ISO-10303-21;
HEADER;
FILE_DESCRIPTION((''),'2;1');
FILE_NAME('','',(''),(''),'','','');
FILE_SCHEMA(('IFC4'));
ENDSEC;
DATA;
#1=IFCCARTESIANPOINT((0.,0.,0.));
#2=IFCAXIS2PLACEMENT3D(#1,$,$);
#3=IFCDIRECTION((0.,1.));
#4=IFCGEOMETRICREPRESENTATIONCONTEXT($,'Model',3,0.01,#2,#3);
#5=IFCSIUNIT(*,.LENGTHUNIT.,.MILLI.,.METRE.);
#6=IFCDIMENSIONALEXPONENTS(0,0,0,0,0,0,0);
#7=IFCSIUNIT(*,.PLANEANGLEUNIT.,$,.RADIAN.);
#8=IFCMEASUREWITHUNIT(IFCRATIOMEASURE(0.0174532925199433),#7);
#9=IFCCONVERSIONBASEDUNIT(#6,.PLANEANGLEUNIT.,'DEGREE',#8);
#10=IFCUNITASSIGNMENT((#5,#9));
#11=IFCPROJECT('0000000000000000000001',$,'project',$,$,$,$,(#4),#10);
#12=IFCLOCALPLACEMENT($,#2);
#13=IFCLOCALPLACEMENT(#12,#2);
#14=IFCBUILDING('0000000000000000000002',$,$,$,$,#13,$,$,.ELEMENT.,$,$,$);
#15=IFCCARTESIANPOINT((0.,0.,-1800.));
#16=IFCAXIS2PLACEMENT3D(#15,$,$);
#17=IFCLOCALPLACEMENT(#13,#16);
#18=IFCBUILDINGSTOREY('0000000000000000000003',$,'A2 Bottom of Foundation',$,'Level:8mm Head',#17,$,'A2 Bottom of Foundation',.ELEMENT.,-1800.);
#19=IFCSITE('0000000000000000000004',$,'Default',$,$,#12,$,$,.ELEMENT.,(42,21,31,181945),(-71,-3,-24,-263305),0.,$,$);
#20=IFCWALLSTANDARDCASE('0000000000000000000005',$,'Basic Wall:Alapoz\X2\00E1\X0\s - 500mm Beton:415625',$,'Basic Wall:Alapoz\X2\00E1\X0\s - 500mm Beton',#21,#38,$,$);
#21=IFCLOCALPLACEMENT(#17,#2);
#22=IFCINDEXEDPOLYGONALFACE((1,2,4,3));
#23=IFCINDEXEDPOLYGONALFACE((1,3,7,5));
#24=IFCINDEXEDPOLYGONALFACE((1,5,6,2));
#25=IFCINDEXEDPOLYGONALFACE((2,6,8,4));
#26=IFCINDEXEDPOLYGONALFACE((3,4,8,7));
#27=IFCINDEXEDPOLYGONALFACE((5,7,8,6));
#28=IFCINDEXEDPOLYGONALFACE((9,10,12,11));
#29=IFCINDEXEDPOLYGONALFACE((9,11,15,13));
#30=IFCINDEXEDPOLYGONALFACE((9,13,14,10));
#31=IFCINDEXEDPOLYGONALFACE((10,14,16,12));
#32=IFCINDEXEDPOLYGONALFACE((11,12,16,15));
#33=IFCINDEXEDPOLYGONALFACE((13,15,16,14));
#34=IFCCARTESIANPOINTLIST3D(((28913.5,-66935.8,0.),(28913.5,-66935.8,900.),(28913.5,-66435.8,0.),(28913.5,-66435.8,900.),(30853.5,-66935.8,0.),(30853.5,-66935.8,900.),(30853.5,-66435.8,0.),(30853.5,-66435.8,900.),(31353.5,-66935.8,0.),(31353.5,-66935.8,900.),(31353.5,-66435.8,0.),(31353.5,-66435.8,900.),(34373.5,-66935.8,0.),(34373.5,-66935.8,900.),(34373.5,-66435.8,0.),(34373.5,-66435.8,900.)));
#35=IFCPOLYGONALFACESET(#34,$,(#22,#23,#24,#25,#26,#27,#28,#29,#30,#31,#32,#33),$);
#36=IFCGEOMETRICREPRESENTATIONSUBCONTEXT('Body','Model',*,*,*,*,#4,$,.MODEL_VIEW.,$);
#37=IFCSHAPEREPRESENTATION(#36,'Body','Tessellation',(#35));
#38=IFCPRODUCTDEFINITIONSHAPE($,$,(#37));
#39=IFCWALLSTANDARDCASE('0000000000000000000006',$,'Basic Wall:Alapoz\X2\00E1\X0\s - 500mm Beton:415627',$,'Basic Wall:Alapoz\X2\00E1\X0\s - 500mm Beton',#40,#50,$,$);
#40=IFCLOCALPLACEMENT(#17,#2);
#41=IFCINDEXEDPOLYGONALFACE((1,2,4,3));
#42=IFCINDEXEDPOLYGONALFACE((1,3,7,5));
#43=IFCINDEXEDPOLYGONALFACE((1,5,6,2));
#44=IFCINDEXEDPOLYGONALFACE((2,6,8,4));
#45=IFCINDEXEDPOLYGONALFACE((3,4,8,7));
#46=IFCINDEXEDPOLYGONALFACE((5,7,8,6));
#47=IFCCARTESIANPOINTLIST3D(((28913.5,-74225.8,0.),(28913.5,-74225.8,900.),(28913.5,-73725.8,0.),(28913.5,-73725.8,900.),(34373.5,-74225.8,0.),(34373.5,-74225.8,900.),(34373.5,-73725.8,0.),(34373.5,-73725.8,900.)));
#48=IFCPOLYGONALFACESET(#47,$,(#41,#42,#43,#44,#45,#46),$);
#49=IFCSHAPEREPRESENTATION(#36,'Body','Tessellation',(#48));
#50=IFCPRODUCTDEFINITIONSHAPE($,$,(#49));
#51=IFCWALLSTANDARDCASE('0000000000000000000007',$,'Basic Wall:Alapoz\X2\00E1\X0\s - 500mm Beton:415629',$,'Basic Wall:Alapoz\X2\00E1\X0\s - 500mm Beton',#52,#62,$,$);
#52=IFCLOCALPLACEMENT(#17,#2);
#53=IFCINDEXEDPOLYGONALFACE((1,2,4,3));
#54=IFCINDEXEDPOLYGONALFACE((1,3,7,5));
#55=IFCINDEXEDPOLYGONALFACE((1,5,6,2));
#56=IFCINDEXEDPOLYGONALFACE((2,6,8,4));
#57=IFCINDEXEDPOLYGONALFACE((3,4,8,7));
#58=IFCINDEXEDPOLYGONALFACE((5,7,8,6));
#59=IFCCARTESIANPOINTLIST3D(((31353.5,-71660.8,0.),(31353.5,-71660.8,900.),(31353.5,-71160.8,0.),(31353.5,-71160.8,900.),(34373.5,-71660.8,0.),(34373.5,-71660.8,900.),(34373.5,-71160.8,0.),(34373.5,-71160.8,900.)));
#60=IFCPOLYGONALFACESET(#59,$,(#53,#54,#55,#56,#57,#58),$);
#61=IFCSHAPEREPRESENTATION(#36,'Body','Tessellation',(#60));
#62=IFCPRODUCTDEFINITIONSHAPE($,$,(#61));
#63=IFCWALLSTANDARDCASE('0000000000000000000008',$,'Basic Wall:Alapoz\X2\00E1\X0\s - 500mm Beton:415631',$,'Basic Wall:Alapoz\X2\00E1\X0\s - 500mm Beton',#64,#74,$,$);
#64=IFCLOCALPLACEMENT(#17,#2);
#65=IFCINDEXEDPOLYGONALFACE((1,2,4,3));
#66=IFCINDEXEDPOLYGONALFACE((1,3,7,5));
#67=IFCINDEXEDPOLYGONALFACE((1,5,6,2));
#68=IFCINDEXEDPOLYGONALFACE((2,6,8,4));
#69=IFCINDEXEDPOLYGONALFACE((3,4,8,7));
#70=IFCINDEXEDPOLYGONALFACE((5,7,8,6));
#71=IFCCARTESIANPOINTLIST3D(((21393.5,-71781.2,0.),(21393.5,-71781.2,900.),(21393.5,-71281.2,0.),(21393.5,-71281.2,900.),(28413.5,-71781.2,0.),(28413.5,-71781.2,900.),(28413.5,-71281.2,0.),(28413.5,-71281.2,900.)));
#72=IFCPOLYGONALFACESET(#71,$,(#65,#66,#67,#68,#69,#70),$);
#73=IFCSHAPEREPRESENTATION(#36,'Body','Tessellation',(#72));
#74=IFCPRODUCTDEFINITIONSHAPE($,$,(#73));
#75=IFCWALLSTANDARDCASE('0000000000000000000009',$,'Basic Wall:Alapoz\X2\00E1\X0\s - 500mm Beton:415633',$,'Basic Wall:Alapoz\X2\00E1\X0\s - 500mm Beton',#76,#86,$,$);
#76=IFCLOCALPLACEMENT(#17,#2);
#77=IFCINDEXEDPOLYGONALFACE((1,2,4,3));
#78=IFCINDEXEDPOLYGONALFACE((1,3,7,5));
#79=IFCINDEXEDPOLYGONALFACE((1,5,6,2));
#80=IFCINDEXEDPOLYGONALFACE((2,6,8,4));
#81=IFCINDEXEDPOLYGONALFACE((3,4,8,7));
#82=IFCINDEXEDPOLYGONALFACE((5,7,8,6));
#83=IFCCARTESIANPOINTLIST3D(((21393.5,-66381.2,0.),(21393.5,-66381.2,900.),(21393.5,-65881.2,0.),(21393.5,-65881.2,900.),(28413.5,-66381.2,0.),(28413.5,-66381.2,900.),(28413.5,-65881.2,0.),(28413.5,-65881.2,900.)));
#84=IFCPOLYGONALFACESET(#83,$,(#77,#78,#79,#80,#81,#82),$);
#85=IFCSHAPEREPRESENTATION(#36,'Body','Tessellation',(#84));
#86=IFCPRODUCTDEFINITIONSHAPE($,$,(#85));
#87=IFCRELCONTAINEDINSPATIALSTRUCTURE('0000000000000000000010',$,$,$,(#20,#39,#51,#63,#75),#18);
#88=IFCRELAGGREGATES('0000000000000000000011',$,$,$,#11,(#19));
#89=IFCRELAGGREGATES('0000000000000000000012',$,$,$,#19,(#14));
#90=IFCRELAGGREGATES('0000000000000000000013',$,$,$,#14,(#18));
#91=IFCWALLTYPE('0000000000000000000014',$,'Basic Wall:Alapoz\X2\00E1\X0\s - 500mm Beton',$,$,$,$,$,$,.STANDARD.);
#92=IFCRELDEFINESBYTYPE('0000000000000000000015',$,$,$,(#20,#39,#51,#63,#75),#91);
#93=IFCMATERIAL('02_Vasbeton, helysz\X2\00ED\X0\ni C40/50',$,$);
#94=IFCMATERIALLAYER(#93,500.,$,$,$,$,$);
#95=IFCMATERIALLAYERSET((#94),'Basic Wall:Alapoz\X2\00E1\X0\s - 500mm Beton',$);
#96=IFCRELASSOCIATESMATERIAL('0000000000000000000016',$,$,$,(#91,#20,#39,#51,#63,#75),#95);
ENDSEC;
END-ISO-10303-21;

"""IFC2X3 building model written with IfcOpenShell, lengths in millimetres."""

from ifc_helpers import new_model, entity, si_unit, converted_unit, direction, frame, frame_2d, origin, place, context, subcontext, project, spatial, rectangle, extrude, material, layer, layer_set, layer_usage, type_object, element, save


model = new_model("IFC2X3")

# Units and contexts
model_context = context("Model", 3, precision=0.01, world=origin(), true_north=direction((0.0, 1.0)))
body_context = subcontext(model_context, "Body", "Model", "MODEL_VIEW")
ifc_project = project(units=[si_unit("LENGTHUNIT", "METRE", prefix="MILLI"), converted_unit("PLANEANGLEUNIT", "DEGREE", entity("IfcRatioMeasure", 0.0174532925199433), si_unit("PLANEANGLEUNIT", "RADIAN"), dimensions=[0, 0, 0, 0, 0, 0, 0])], contexts=[model_context])

# Site, building, storey
site_placement = place(None, origin())
site = spatial("IfcSite", under=ifc_project, at=site_placement, Name="Default", CompositionType="ELEMENT", RefLatitude=(42, 21, 31, 181945), RefLongitude=(-71, -3, -24, -263305), RefElevation=0.0)
building_placement = place(site_placement, origin())
building = spatial("IfcBuilding", under=site, at=building_placement, CompositionType="ELEMENT")
storey_placement = place(building_placement, frame((0.0, 0.0, -1800.0)))
storey = spatial("IfcBuildingStorey", under=building, at=storey_placement, Name="A2 Bottom of Foundation", ObjectType="Level:8mm Head", LongName="A2 Bottom of Foundation", CompositionType="ELEMENT", Elevation=-1800.0)

# Shared definitions
ifc_material = material(Name="02_Vasbeton, helyszíni C40/50")
ifc_layer = layer(ifc_material, 500.0)
ifc_layer_set = layer_set([ifc_layer], Name="Basic Wall:Alapozás - 500mm Beton")
wall_type = type_object("IfcWallType", Name="Basic Wall:Alapozás - 500mm Beton", PredefinedType="STANDARD", material=ifc_layer_set)

# Wall, opening
ifc_layer_usage_1 = layer_usage(ifc_layer_set, "AXIS2", "POSITIVE", -250.0)
wall_1_placement = place(storey_placement, frame((28913.5, -66685.8, 0.0)))
wall_1 = element("IfcWallStandardCase", 1, at=wall_1_placement, inside=storey, type_object=wall_type, material=ifc_layer_usage_1, Name="Basic Wall:Alapozás - 500mm Beton:415625", ObjectType="Basic Wall:Alapozás - 500mm Beton", context=body_context, shape_type="SweptSolid", body=[
    extrude(rectangle(XDim=5460.0, YDim=500.0, at=frame_2d((2730.0, 0.0), x_axis=(-1.0, 0.0))), origin(), (0.0, 0.0, 1.0), 900.0),
])
opening_1_placement = place(storey_placement, frame((28913.5, -66685.8, 0.0)))
element("IfcOpeningElement", 2, at=opening_1_placement, cuts=wall_1, ObjectType="Opening", context=body_context, shape_type="SweptSolid", body=[
    extrude(rectangle(XDim=900.0, YDim=500.0, at=frame_2d((0.0, 0.0), x_axis=(1.0, 0.0))), frame((1940.0, 0.0, 450.0), z_axis=(1.0, 0.0, 0.0), x_axis=(0.0, 0.0, -1.0)), (0.0, 0.0, 1.0), 500.0),
])

# Walls
ifc_layer_usage_2 = layer_usage(ifc_layer_set, "AXIS2", "NEGATIVE", 250.0)
wall_2_placement = place(storey_placement, frame((28913.5, -73975.8, 0.0)))
element("IfcWallStandardCase", 3, at=wall_2_placement, inside=storey, type_object=wall_type, material=ifc_layer_usage_2, Name="Basic Wall:Alapozás - 500mm Beton:415627", ObjectType="Basic Wall:Alapozás - 500mm Beton", context=body_context, shape_type="SweptSolid", body=[
    extrude(rectangle(XDim=5460.0, YDim=500.0, at=frame_2d((2730.0, 0.0), x_axis=(-1.0, 0.0))), origin(), (0.0, 0.0, 1.0), 900.0),
])
ifc_layer_usage_3 = layer_usage(ifc_layer_set, "AXIS2", "POSITIVE", -250.0)
wall_3_placement = place(storey_placement, frame((31353.5, -71410.8, 0.0)))
element("IfcWallStandardCase", 4, at=wall_3_placement, inside=storey, type_object=wall_type, material=ifc_layer_usage_3, Name="Basic Wall:Alapozás - 500mm Beton:415629", ObjectType="Basic Wall:Alapozás - 500mm Beton", context=body_context, shape_type="SweptSolid", body=[
    extrude(rectangle(XDim=3020.0, YDim=500.0, at=frame_2d((1510.0, 0.0), x_axis=(-1.0, 0.0))), origin(), (0.0, 0.0, 1.0), 900.0),
])
ifc_layer_usage_4 = layer_usage(ifc_layer_set, "AXIS2", "NEGATIVE", 250.0)
wall_4_placement = place(storey_placement, frame((28413.5, -71531.2, 0.0), z_axis=(0.0, 0.0, 1.0), x_axis=(-1.0, 0.0, 0.0)))
element("IfcWallStandardCase", 5, at=wall_4_placement, inside=storey, type_object=wall_type, material=ifc_layer_usage_4, Name="Basic Wall:Alapozás - 500mm Beton:415631", ObjectType="Basic Wall:Alapozás - 500mm Beton", context=body_context, shape_type="SweptSolid", body=[
    extrude(rectangle(XDim=7020.0, YDim=500.0, at=frame_2d((3510.0, 0.0), x_axis=(-1.0, 0.0))), origin(), (0.0, 0.0, 1.0), 900.0),
])
ifc_layer_usage_5 = layer_usage(ifc_layer_set, "AXIS2", "POSITIVE", -250.0)
wall_5_placement = place(storey_placement, frame((28413.5, -66131.2, 0.0), z_axis=(0.0, 0.0, 1.0), x_axis=(-1.0, 0.0, 0.0)))
element("IfcWallStandardCase", 6, at=wall_5_placement, inside=storey, type_object=wall_type, material=ifc_layer_usage_5, Name="Basic Wall:Alapozás - 500mm Beton:415633", ObjectType="Basic Wall:Alapozás - 500mm Beton", context=body_context, shape_type="SweptSolid", body=[
    extrude(rectangle(XDim=7020.0, YDim=500.0, at=frame_2d((3510.0, 0.0), x_axis=(-1.0, 0.0))), origin(), (0.0, 0.0, 1.0), 900.0),
])

save(model, "model.ifc")
